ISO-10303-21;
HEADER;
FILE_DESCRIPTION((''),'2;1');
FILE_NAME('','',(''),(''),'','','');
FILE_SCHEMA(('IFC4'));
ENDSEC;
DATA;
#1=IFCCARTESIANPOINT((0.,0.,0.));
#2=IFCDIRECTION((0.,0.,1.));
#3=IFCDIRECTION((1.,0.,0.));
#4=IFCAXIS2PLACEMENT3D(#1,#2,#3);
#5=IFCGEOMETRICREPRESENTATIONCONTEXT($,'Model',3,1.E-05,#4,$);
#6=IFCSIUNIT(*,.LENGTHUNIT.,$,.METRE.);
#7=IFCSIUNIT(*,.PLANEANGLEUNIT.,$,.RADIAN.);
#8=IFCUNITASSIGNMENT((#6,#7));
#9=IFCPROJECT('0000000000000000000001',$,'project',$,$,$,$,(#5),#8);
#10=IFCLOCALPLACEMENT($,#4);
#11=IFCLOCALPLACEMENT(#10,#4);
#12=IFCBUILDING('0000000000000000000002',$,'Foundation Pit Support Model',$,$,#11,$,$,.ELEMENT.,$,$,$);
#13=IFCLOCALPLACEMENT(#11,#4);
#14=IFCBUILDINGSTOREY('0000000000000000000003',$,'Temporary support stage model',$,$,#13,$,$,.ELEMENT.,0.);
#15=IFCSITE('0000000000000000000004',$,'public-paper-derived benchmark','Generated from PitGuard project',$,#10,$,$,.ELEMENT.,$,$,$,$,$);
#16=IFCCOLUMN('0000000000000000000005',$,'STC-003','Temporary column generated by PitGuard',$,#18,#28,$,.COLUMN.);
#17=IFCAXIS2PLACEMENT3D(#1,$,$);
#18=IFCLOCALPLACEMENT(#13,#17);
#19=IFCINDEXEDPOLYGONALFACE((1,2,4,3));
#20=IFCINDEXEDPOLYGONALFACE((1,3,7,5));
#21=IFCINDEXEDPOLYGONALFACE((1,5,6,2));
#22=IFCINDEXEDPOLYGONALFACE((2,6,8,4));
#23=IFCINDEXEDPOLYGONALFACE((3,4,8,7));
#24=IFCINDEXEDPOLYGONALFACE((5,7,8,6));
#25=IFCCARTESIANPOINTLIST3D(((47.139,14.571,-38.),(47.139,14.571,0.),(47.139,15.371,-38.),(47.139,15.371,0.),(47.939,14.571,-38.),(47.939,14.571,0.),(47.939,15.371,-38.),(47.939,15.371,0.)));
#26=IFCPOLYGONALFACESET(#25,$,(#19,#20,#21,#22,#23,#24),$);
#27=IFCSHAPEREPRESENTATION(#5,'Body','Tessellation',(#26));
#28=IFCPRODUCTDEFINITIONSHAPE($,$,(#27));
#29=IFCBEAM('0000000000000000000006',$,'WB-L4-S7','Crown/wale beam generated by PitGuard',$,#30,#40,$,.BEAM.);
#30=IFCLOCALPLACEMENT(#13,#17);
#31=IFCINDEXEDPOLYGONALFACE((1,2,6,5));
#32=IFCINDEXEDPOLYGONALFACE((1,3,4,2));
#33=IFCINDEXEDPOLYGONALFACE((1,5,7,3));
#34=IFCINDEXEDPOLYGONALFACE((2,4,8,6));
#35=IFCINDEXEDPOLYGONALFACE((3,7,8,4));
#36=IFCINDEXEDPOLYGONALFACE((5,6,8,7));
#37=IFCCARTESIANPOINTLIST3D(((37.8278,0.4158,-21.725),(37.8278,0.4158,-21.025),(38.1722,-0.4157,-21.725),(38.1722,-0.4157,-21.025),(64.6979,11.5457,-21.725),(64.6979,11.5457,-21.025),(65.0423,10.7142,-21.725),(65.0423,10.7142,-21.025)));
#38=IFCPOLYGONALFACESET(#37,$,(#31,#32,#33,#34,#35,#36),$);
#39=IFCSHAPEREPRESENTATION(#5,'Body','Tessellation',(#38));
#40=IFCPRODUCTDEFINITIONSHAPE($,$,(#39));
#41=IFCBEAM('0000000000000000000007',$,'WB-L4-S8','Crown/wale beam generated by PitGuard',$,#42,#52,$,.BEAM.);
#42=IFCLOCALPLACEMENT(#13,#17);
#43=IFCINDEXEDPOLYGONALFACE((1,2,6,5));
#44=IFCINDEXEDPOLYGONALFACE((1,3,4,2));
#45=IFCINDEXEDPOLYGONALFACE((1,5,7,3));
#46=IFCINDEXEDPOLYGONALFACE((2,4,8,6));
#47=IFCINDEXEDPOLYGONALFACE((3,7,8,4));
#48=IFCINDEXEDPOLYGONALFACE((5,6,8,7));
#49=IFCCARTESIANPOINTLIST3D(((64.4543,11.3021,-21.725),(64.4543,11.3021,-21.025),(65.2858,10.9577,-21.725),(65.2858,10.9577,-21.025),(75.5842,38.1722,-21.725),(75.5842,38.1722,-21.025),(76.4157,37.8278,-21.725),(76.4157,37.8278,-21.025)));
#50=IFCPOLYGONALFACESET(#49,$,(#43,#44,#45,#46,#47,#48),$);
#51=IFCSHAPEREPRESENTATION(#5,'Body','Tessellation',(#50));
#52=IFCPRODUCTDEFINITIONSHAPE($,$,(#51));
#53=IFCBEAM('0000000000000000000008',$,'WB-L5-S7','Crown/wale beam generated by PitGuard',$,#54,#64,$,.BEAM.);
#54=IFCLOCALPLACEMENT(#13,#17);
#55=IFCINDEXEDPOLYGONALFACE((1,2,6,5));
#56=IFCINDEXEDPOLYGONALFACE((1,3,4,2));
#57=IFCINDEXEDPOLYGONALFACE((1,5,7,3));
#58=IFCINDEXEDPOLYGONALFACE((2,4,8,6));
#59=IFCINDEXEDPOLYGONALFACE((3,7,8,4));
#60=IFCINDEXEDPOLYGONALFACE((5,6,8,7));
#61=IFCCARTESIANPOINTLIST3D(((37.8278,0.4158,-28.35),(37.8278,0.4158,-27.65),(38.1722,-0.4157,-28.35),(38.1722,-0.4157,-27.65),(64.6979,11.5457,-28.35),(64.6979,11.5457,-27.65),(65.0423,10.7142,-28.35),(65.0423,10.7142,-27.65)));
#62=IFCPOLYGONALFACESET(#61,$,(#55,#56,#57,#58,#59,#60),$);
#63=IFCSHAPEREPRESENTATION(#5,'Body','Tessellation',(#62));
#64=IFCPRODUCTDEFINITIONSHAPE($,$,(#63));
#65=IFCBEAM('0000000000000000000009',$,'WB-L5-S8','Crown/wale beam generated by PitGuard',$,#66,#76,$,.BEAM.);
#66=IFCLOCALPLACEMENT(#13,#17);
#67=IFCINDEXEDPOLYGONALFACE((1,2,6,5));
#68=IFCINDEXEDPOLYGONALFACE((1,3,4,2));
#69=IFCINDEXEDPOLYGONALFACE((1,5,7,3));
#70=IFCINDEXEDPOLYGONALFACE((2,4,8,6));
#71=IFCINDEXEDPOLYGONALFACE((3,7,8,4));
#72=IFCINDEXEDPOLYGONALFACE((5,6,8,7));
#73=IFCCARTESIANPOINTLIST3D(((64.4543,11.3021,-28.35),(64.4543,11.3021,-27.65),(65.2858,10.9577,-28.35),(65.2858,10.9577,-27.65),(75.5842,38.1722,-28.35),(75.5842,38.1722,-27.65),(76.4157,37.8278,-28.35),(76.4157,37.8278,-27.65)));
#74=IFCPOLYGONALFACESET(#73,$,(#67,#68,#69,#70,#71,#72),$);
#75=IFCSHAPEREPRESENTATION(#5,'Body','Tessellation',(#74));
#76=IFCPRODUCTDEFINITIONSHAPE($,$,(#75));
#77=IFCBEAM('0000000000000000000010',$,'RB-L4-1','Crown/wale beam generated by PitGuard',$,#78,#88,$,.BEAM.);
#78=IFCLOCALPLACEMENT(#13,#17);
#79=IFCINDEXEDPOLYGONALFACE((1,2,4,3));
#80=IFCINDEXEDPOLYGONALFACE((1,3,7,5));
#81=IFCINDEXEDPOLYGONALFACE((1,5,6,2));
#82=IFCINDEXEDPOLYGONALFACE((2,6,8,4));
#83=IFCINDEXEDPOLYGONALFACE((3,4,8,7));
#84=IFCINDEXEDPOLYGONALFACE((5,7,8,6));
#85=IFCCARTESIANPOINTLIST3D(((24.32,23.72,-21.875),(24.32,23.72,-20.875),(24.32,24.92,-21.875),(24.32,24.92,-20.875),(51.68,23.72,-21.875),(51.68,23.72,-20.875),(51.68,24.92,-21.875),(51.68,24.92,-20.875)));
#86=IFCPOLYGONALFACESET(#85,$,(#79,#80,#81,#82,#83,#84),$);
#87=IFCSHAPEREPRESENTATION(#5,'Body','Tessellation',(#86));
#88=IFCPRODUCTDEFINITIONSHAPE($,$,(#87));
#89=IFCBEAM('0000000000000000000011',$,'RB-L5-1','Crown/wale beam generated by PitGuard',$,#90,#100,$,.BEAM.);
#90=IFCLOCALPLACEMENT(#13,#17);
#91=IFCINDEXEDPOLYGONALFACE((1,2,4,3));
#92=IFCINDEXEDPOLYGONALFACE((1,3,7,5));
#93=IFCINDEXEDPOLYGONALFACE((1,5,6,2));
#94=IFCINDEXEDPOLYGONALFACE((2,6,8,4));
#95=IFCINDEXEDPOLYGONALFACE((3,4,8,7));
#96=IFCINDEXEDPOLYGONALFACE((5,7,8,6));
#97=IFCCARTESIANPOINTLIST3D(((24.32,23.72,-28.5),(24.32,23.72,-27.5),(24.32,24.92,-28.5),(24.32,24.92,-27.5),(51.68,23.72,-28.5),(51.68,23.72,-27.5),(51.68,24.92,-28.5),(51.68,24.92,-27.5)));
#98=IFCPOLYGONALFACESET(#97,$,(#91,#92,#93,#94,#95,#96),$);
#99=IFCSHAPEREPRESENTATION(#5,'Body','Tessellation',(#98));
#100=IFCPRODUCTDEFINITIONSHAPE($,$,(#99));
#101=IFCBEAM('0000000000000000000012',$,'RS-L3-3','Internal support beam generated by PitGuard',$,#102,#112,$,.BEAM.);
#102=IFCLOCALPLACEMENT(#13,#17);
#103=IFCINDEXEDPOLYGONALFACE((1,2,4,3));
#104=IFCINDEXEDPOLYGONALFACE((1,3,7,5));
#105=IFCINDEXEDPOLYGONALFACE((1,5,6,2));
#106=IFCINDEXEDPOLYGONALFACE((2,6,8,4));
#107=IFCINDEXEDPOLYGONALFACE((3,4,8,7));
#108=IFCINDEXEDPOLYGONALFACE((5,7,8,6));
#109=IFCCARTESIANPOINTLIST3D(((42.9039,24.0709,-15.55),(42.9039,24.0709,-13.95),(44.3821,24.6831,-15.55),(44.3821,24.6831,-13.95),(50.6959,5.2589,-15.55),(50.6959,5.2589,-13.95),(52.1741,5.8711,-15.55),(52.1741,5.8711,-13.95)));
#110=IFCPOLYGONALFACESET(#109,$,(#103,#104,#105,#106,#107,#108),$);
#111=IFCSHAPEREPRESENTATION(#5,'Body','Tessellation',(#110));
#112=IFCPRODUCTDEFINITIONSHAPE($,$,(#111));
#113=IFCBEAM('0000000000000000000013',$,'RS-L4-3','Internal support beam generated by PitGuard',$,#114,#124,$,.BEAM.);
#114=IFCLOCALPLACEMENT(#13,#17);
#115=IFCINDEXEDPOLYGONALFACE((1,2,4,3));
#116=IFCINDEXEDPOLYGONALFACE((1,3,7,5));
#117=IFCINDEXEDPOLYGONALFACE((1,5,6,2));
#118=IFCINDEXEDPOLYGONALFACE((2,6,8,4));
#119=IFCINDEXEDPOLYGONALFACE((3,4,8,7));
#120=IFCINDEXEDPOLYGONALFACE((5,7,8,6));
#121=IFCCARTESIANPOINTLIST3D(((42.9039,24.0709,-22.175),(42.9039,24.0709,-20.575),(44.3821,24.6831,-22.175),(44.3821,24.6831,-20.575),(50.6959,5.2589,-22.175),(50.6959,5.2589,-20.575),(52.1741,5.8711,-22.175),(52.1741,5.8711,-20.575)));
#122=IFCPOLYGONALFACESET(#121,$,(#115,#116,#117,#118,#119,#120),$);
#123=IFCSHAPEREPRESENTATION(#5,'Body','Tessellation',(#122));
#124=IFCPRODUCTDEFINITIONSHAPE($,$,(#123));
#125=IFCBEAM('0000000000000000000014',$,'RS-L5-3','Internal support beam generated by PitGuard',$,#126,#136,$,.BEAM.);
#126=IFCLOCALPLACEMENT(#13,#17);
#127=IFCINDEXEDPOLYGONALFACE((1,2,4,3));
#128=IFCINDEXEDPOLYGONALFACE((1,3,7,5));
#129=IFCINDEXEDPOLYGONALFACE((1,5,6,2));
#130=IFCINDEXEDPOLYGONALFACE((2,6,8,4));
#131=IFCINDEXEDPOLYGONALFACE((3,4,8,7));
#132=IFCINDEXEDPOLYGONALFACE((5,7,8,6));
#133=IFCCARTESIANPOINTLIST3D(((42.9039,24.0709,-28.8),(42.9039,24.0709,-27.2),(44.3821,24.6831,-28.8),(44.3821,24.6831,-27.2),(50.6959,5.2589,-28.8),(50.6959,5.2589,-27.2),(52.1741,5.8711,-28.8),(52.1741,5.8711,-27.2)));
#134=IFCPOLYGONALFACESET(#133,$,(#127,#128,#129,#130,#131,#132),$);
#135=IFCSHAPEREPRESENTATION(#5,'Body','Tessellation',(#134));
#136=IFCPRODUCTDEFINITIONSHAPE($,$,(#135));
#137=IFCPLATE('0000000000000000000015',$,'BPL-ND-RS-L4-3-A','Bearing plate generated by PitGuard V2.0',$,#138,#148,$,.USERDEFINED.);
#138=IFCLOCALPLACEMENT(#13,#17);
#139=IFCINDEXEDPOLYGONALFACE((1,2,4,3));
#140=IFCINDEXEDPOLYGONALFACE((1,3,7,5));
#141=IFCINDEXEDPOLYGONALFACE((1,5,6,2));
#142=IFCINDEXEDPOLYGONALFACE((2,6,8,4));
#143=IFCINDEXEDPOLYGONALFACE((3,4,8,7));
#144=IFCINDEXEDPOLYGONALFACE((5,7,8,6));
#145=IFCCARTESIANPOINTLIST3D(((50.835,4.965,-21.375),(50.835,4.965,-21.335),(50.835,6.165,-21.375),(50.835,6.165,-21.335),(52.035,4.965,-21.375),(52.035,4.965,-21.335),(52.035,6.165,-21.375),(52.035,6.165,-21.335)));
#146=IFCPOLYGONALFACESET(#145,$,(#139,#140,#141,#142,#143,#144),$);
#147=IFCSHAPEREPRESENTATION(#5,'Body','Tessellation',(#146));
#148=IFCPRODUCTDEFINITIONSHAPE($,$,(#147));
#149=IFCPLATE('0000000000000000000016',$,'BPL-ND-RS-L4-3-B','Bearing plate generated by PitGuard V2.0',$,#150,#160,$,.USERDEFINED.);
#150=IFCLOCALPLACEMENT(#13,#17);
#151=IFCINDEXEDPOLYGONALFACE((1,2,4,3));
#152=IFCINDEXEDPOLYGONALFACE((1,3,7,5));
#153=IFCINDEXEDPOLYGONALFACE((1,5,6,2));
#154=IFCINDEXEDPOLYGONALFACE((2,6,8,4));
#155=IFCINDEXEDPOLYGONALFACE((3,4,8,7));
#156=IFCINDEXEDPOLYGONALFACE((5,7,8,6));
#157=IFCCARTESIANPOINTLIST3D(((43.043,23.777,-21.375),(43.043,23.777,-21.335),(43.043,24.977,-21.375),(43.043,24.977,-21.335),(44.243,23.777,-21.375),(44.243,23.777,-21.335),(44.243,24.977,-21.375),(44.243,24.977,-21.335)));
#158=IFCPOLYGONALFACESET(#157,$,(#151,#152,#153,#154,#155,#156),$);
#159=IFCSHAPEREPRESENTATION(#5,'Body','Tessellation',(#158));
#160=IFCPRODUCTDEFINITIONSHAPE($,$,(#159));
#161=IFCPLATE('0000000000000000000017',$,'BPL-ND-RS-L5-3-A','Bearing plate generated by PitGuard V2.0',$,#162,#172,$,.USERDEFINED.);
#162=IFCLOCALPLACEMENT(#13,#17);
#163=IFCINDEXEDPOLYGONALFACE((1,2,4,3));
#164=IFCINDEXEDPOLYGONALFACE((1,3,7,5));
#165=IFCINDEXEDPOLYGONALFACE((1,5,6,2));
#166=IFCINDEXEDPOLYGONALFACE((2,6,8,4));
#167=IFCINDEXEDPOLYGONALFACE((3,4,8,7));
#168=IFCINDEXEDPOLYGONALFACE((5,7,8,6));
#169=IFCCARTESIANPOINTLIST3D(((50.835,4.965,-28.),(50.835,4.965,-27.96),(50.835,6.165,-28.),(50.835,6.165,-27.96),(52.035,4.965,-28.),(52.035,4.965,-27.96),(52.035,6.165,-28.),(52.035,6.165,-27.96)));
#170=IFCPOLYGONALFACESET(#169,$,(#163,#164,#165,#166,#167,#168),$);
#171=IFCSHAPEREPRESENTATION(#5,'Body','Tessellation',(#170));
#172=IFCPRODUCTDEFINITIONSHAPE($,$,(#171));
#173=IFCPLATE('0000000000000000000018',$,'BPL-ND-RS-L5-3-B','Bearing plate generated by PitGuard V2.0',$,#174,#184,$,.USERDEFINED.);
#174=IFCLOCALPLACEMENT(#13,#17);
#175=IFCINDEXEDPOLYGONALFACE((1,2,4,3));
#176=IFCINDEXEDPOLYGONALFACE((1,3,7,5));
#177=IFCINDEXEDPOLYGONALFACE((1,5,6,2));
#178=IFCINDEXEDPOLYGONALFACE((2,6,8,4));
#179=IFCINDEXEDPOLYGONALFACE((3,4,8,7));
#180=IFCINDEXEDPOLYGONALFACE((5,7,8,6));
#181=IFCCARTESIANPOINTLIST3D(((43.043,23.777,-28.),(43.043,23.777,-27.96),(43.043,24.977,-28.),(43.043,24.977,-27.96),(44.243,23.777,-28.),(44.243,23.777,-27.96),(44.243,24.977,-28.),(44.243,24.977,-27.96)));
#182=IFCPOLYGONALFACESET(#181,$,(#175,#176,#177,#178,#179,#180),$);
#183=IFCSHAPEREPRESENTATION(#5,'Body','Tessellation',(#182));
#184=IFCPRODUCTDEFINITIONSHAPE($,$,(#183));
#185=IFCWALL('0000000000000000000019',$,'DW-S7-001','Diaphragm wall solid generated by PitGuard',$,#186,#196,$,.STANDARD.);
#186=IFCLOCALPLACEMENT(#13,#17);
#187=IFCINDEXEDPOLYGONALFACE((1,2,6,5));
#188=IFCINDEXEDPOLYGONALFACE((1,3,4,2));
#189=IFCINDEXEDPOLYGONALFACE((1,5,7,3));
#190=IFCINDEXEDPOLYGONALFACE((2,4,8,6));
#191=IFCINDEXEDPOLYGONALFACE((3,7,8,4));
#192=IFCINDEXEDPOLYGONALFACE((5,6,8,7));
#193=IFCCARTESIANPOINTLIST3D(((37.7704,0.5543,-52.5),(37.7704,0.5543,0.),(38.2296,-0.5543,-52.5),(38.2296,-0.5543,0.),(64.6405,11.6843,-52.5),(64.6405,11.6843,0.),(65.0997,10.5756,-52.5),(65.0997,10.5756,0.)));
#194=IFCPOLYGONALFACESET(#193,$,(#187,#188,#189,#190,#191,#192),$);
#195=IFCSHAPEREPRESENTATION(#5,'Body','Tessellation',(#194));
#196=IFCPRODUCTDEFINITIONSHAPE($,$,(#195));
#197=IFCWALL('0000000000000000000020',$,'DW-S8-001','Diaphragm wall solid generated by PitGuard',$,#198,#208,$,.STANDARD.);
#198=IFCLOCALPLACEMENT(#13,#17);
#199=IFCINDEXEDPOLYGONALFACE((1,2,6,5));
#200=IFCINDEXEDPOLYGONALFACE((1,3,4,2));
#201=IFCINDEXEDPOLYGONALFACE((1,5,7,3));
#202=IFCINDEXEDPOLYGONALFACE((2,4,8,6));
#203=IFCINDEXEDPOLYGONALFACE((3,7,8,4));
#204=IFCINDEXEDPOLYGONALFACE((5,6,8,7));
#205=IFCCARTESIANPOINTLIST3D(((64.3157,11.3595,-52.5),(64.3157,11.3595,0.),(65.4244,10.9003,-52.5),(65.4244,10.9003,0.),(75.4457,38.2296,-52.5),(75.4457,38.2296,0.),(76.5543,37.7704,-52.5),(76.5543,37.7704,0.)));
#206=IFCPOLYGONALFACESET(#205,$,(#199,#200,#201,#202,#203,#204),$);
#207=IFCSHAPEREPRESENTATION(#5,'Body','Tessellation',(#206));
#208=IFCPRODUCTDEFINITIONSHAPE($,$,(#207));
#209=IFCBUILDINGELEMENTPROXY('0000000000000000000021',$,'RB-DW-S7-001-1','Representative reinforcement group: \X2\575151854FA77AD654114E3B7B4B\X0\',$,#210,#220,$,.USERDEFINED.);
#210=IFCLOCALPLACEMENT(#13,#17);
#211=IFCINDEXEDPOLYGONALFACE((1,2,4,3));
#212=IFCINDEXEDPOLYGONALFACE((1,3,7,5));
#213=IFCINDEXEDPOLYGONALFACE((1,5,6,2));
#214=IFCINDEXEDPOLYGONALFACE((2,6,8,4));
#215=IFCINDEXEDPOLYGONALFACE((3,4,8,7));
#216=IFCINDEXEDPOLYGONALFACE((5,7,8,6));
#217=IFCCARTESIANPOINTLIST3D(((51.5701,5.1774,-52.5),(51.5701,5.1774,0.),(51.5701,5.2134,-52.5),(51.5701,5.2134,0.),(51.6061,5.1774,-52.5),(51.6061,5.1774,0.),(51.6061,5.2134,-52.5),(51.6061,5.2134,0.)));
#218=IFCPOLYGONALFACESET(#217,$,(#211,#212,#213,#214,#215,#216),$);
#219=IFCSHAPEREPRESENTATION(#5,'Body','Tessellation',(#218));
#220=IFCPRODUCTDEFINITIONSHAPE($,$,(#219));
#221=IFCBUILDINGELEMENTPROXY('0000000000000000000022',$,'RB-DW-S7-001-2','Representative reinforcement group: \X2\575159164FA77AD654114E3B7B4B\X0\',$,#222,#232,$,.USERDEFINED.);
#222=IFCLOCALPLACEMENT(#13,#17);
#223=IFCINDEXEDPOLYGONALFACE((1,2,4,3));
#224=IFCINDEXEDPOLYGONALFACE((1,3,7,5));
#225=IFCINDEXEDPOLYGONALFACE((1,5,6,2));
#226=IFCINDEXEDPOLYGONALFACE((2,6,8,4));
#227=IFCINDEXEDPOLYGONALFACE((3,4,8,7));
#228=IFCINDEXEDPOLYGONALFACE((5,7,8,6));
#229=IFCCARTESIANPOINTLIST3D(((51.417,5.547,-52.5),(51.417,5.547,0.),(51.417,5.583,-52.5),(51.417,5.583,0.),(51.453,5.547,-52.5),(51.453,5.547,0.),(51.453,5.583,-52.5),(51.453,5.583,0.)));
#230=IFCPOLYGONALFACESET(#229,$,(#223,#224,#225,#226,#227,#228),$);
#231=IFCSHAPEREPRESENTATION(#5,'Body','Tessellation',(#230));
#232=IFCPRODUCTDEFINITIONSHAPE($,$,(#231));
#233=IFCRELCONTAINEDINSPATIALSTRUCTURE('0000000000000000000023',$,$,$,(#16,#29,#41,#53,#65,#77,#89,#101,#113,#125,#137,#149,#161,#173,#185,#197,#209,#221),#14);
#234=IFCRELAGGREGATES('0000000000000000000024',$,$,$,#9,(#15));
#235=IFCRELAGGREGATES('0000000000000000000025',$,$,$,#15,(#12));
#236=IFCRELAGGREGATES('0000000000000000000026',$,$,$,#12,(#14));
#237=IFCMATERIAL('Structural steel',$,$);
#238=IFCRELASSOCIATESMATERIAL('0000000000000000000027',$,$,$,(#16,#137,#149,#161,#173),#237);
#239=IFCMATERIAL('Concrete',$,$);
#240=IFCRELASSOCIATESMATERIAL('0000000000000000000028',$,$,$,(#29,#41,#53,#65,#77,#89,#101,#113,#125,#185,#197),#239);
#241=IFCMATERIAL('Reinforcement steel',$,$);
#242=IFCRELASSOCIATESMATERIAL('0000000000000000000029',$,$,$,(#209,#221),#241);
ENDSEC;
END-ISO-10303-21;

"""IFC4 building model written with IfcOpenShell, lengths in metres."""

from ifc_helpers import new_model, si_unit, frame, origin_with_axes, origin_2d, place, context, project, spatial, rectangle, extrude, material, element, save


model = new_model("IFC4")

# Units and contexts
model_context = context("Model", 3, precision=1e-05, world=origin_with_axes())
ifc_project = project(units=[si_unit("LENGTHUNIT", "METRE"), si_unit("PLANEANGLEUNIT", "RADIAN")], contexts=[model_context])

# Site, building, storey
site_placement = place(None, origin_with_axes())
site = spatial("IfcSite", under=ifc_project, at=site_placement, Name="public-paper-derived benchmark", Description="Generated from PitGuard project", CompositionType="ELEMENT")
building_placement = place(site_placement, origin_with_axes())
building = spatial("IfcBuilding", under=site, at=building_placement, Name="Foundation Pit Support Model", CompositionType="ELEMENT")
storey_placement = place(building_placement, origin_with_axes())
storey = spatial("IfcBuildingStorey", under=building, at=storey_placement, Name="Temporary support stage model", CompositionType="ELEMENT", Elevation=0.0)

# Column
ifc_material_1 = material(Name="Structural steel")
column_placement = place(storey_placement, frame((47.539, 14.971, -38.0), z_axis=(0.0, 0.0, 1.0), x_axis=(1.0, 0.0, 0.0)))
element("IfcColumn", 1, at=column_placement, inside=storey, material=ifc_material_1, Name="STC-003", Description="Temporary column generated by PitGuard", PredefinedType="COLUMN", context=model_context, shape_type="SweptSolid", body=[
    extrude(rectangle(XDim=0.8, YDim=0.8, at=origin_2d()), origin_with_axes(), (0.0, 0.0, 1.0), 38.0),
])

# Beams
ifc_material_2 = material(Name="Concrete")
for number, where, z_axis, x_axis, name in (
    (2, (51.435, 5.565, -21.725), (0.0, 0.0, 1.0), (0.92388, 0.382683, 0.0), "WB-L4-S7"),
    (3, (70.435, 24.565, -21.725), (0.0, 0.0, 1.0), (0.382683, 0.92388, 0.0), "WB-L4-S8"),
    (4, (51.435, 5.565, -28.35), (0.0, 0.0, 1.0), (0.92388, 0.382683, 0.0), "WB-L5-S7"),
    (5, (70.435, 24.565, -28.35), (0.0, 0.0, 1.0), (0.382683, 0.92388, 0.0), "WB-L5-S8"),
):
    element("IfcBeam", number, at=place(storey_placement, frame(where, z_axis=z_axis, x_axis=x_axis)), inside=storey, material=ifc_material_2, Name=name, Description="Crown/wale beam generated by PitGuard", PredefinedType="BEAM", context=model_context, shape_type="SweptSolid", body=[
        extrude(rectangle(XDim=29.0839, YDim=0.9, at=origin_2d()), origin_with_axes(), (0.0, 0.0, 1.0), 0.7),
    ])
for number, where, z_axis, x_axis, name in (
    (6, (38.0, 24.32, -21.875), (0.0, 0.0, 1.0), (1.0, 0.0, 0.0), "RB-L4-1"),
    (7, (38.0, 24.32, -28.5), (0.0, 0.0, 1.0), (1.0, 0.0, 0.0), "RB-L5-1"),
):
    element("IfcBeam", number, at=place(storey_placement, frame(where, z_axis=z_axis, x_axis=x_axis)), inside=storey, material=ifc_material_2, Name=name, Description="Crown/wale beam generated by PitGuard", PredefinedType="BEAM", context=model_context, shape_type="SweptSolid", body=[
        extrude(rectangle(XDim=27.36, YDim=1.2, at=origin_2d()), origin_with_axes(), (0.0, 0.0, 1.0), 1.0),
    ])
for number, where, z_axis, x_axis, name in (
    (8, (47.539, 14.971, -15.55), (0.0, 0.0, 1.0), (-0.382676, 0.923883, 0.0), "RS-L3-3"),
    (9, (47.539, 14.971, -22.175), (0.0, 0.0, 1.0), (-0.382676, 0.923883, 0.0), "RS-L4-3"),
    (10, (47.539, 14.971, -28.8), (0.0, 0.0, 1.0), (-0.382676, 0.923883, 0.0), "RS-L5-3"),
):
    element("IfcBeam", number, at=place(storey_placement, frame(where, z_axis=z_axis, x_axis=x_axis)), inside=storey, material=ifc_material_2, Name=name, Description="Internal support beam generated by PitGuard", PredefinedType="BEAM", context=model_context, shape_type="SweptSolid", body=[
        extrude(rectangle(XDim=20.3619, YDim=1.6, at=origin_2d()), origin_with_axes(), (0.0, 0.0, 1.0), 1.6),
    ])

# Plates
for number, where, z_axis, x_axis, name in (
    (11, (51.435, 5.565, -21.375), (0.0, 0.0, 1.0), (1.0, 0.0, 0.0), "BPL-ND-RS-L4-3-A"),
    (12, (43.643, 24.377, -21.375), (0.0, 0.0, 1.0), (1.0, 0.0, 0.0), "BPL-ND-RS-L4-3-B"),
    (13, (51.435, 5.565, -28.0), (0.0, 0.0, 1.0), (1.0, 0.0, 0.0), "BPL-ND-RS-L5-3-A"),
    (14, (43.643, 24.377, -28.0), (0.0, 0.0, 1.0), (1.0, 0.0, 0.0), "BPL-ND-RS-L5-3-B"),
):
    element("IfcPlate", number, at=place(storey_placement, frame(where, z_axis=z_axis, x_axis=x_axis)), inside=storey, material=ifc_material_1, Name=name, Description="Bearing plate generated by PitGuard V2.0", PredefinedType="USERDEFINED", context=model_context, shape_type="SweptSolid", body=[
        extrude(rectangle(XDim=1.2, YDim=1.2, at=origin_2d()), origin_with_axes(), (0.0, 0.0, 1.0), 0.04),
    ])

# Walls
for number, where, z_axis, x_axis, name in (
    (15, (51.435, 5.565, -52.5), (0.0, 0.0, 1.0), (0.92388, 0.382683, 0.0), "DW-S7-001"),
    (16, (70.435, 24.565, -52.5), (0.0, 0.0, 1.0), (0.382683, 0.92388, 0.0), "DW-S8-001"),
):
    element("IfcWall", number, at=place(storey_placement, frame(where, z_axis=z_axis, x_axis=x_axis)), inside=storey, material=ifc_material_2, Name=name, Description="Diaphragm wall solid generated by PitGuard", PredefinedType="STANDARD", context=model_context, shape_type="SweptSolid", body=[
        extrude(rectangle(XDim=29.0839, YDim=1.2, at=origin_2d()), origin_with_axes(), (0.0, 0.0, 1.0), 52.5),
    ])

# Building element proxies
ifc_material_3 = material(Name="Reinforcement steel")
for number, where, z_axis, x_axis, name, description in (
    (17, (51.5881, 5.1954, -52.5), (0.0, 0.0, 1.0), (1.0, 0.0, 0.0), "RB-DW-S7-001-1", "Representative reinforcement group: 坑内侧竖向主筋"),
    (18, (51.435, 5.565, -52.5), (0.0, 0.0, 1.0), (1.0, 0.0, 0.0), "RB-DW-S7-001-2", "Representative reinforcement group: 坑外侧竖向主筋"),
):
    element("IfcBuildingElementProxy", number, at=place(storey_placement, frame(where, z_axis=z_axis, x_axis=x_axis)), inside=storey, material=ifc_material_3, Name=name, Description=description, PredefinedType="USERDEFINED", context=model_context, shape_type="SweptSolid", body=[
        extrude(rectangle(XDim=0.036, YDim=0.036, at=origin_2d()), origin_with_axes(), (0.0, 0.0, 1.0), 52.5),
    ])

save(model, "model.ifc")
